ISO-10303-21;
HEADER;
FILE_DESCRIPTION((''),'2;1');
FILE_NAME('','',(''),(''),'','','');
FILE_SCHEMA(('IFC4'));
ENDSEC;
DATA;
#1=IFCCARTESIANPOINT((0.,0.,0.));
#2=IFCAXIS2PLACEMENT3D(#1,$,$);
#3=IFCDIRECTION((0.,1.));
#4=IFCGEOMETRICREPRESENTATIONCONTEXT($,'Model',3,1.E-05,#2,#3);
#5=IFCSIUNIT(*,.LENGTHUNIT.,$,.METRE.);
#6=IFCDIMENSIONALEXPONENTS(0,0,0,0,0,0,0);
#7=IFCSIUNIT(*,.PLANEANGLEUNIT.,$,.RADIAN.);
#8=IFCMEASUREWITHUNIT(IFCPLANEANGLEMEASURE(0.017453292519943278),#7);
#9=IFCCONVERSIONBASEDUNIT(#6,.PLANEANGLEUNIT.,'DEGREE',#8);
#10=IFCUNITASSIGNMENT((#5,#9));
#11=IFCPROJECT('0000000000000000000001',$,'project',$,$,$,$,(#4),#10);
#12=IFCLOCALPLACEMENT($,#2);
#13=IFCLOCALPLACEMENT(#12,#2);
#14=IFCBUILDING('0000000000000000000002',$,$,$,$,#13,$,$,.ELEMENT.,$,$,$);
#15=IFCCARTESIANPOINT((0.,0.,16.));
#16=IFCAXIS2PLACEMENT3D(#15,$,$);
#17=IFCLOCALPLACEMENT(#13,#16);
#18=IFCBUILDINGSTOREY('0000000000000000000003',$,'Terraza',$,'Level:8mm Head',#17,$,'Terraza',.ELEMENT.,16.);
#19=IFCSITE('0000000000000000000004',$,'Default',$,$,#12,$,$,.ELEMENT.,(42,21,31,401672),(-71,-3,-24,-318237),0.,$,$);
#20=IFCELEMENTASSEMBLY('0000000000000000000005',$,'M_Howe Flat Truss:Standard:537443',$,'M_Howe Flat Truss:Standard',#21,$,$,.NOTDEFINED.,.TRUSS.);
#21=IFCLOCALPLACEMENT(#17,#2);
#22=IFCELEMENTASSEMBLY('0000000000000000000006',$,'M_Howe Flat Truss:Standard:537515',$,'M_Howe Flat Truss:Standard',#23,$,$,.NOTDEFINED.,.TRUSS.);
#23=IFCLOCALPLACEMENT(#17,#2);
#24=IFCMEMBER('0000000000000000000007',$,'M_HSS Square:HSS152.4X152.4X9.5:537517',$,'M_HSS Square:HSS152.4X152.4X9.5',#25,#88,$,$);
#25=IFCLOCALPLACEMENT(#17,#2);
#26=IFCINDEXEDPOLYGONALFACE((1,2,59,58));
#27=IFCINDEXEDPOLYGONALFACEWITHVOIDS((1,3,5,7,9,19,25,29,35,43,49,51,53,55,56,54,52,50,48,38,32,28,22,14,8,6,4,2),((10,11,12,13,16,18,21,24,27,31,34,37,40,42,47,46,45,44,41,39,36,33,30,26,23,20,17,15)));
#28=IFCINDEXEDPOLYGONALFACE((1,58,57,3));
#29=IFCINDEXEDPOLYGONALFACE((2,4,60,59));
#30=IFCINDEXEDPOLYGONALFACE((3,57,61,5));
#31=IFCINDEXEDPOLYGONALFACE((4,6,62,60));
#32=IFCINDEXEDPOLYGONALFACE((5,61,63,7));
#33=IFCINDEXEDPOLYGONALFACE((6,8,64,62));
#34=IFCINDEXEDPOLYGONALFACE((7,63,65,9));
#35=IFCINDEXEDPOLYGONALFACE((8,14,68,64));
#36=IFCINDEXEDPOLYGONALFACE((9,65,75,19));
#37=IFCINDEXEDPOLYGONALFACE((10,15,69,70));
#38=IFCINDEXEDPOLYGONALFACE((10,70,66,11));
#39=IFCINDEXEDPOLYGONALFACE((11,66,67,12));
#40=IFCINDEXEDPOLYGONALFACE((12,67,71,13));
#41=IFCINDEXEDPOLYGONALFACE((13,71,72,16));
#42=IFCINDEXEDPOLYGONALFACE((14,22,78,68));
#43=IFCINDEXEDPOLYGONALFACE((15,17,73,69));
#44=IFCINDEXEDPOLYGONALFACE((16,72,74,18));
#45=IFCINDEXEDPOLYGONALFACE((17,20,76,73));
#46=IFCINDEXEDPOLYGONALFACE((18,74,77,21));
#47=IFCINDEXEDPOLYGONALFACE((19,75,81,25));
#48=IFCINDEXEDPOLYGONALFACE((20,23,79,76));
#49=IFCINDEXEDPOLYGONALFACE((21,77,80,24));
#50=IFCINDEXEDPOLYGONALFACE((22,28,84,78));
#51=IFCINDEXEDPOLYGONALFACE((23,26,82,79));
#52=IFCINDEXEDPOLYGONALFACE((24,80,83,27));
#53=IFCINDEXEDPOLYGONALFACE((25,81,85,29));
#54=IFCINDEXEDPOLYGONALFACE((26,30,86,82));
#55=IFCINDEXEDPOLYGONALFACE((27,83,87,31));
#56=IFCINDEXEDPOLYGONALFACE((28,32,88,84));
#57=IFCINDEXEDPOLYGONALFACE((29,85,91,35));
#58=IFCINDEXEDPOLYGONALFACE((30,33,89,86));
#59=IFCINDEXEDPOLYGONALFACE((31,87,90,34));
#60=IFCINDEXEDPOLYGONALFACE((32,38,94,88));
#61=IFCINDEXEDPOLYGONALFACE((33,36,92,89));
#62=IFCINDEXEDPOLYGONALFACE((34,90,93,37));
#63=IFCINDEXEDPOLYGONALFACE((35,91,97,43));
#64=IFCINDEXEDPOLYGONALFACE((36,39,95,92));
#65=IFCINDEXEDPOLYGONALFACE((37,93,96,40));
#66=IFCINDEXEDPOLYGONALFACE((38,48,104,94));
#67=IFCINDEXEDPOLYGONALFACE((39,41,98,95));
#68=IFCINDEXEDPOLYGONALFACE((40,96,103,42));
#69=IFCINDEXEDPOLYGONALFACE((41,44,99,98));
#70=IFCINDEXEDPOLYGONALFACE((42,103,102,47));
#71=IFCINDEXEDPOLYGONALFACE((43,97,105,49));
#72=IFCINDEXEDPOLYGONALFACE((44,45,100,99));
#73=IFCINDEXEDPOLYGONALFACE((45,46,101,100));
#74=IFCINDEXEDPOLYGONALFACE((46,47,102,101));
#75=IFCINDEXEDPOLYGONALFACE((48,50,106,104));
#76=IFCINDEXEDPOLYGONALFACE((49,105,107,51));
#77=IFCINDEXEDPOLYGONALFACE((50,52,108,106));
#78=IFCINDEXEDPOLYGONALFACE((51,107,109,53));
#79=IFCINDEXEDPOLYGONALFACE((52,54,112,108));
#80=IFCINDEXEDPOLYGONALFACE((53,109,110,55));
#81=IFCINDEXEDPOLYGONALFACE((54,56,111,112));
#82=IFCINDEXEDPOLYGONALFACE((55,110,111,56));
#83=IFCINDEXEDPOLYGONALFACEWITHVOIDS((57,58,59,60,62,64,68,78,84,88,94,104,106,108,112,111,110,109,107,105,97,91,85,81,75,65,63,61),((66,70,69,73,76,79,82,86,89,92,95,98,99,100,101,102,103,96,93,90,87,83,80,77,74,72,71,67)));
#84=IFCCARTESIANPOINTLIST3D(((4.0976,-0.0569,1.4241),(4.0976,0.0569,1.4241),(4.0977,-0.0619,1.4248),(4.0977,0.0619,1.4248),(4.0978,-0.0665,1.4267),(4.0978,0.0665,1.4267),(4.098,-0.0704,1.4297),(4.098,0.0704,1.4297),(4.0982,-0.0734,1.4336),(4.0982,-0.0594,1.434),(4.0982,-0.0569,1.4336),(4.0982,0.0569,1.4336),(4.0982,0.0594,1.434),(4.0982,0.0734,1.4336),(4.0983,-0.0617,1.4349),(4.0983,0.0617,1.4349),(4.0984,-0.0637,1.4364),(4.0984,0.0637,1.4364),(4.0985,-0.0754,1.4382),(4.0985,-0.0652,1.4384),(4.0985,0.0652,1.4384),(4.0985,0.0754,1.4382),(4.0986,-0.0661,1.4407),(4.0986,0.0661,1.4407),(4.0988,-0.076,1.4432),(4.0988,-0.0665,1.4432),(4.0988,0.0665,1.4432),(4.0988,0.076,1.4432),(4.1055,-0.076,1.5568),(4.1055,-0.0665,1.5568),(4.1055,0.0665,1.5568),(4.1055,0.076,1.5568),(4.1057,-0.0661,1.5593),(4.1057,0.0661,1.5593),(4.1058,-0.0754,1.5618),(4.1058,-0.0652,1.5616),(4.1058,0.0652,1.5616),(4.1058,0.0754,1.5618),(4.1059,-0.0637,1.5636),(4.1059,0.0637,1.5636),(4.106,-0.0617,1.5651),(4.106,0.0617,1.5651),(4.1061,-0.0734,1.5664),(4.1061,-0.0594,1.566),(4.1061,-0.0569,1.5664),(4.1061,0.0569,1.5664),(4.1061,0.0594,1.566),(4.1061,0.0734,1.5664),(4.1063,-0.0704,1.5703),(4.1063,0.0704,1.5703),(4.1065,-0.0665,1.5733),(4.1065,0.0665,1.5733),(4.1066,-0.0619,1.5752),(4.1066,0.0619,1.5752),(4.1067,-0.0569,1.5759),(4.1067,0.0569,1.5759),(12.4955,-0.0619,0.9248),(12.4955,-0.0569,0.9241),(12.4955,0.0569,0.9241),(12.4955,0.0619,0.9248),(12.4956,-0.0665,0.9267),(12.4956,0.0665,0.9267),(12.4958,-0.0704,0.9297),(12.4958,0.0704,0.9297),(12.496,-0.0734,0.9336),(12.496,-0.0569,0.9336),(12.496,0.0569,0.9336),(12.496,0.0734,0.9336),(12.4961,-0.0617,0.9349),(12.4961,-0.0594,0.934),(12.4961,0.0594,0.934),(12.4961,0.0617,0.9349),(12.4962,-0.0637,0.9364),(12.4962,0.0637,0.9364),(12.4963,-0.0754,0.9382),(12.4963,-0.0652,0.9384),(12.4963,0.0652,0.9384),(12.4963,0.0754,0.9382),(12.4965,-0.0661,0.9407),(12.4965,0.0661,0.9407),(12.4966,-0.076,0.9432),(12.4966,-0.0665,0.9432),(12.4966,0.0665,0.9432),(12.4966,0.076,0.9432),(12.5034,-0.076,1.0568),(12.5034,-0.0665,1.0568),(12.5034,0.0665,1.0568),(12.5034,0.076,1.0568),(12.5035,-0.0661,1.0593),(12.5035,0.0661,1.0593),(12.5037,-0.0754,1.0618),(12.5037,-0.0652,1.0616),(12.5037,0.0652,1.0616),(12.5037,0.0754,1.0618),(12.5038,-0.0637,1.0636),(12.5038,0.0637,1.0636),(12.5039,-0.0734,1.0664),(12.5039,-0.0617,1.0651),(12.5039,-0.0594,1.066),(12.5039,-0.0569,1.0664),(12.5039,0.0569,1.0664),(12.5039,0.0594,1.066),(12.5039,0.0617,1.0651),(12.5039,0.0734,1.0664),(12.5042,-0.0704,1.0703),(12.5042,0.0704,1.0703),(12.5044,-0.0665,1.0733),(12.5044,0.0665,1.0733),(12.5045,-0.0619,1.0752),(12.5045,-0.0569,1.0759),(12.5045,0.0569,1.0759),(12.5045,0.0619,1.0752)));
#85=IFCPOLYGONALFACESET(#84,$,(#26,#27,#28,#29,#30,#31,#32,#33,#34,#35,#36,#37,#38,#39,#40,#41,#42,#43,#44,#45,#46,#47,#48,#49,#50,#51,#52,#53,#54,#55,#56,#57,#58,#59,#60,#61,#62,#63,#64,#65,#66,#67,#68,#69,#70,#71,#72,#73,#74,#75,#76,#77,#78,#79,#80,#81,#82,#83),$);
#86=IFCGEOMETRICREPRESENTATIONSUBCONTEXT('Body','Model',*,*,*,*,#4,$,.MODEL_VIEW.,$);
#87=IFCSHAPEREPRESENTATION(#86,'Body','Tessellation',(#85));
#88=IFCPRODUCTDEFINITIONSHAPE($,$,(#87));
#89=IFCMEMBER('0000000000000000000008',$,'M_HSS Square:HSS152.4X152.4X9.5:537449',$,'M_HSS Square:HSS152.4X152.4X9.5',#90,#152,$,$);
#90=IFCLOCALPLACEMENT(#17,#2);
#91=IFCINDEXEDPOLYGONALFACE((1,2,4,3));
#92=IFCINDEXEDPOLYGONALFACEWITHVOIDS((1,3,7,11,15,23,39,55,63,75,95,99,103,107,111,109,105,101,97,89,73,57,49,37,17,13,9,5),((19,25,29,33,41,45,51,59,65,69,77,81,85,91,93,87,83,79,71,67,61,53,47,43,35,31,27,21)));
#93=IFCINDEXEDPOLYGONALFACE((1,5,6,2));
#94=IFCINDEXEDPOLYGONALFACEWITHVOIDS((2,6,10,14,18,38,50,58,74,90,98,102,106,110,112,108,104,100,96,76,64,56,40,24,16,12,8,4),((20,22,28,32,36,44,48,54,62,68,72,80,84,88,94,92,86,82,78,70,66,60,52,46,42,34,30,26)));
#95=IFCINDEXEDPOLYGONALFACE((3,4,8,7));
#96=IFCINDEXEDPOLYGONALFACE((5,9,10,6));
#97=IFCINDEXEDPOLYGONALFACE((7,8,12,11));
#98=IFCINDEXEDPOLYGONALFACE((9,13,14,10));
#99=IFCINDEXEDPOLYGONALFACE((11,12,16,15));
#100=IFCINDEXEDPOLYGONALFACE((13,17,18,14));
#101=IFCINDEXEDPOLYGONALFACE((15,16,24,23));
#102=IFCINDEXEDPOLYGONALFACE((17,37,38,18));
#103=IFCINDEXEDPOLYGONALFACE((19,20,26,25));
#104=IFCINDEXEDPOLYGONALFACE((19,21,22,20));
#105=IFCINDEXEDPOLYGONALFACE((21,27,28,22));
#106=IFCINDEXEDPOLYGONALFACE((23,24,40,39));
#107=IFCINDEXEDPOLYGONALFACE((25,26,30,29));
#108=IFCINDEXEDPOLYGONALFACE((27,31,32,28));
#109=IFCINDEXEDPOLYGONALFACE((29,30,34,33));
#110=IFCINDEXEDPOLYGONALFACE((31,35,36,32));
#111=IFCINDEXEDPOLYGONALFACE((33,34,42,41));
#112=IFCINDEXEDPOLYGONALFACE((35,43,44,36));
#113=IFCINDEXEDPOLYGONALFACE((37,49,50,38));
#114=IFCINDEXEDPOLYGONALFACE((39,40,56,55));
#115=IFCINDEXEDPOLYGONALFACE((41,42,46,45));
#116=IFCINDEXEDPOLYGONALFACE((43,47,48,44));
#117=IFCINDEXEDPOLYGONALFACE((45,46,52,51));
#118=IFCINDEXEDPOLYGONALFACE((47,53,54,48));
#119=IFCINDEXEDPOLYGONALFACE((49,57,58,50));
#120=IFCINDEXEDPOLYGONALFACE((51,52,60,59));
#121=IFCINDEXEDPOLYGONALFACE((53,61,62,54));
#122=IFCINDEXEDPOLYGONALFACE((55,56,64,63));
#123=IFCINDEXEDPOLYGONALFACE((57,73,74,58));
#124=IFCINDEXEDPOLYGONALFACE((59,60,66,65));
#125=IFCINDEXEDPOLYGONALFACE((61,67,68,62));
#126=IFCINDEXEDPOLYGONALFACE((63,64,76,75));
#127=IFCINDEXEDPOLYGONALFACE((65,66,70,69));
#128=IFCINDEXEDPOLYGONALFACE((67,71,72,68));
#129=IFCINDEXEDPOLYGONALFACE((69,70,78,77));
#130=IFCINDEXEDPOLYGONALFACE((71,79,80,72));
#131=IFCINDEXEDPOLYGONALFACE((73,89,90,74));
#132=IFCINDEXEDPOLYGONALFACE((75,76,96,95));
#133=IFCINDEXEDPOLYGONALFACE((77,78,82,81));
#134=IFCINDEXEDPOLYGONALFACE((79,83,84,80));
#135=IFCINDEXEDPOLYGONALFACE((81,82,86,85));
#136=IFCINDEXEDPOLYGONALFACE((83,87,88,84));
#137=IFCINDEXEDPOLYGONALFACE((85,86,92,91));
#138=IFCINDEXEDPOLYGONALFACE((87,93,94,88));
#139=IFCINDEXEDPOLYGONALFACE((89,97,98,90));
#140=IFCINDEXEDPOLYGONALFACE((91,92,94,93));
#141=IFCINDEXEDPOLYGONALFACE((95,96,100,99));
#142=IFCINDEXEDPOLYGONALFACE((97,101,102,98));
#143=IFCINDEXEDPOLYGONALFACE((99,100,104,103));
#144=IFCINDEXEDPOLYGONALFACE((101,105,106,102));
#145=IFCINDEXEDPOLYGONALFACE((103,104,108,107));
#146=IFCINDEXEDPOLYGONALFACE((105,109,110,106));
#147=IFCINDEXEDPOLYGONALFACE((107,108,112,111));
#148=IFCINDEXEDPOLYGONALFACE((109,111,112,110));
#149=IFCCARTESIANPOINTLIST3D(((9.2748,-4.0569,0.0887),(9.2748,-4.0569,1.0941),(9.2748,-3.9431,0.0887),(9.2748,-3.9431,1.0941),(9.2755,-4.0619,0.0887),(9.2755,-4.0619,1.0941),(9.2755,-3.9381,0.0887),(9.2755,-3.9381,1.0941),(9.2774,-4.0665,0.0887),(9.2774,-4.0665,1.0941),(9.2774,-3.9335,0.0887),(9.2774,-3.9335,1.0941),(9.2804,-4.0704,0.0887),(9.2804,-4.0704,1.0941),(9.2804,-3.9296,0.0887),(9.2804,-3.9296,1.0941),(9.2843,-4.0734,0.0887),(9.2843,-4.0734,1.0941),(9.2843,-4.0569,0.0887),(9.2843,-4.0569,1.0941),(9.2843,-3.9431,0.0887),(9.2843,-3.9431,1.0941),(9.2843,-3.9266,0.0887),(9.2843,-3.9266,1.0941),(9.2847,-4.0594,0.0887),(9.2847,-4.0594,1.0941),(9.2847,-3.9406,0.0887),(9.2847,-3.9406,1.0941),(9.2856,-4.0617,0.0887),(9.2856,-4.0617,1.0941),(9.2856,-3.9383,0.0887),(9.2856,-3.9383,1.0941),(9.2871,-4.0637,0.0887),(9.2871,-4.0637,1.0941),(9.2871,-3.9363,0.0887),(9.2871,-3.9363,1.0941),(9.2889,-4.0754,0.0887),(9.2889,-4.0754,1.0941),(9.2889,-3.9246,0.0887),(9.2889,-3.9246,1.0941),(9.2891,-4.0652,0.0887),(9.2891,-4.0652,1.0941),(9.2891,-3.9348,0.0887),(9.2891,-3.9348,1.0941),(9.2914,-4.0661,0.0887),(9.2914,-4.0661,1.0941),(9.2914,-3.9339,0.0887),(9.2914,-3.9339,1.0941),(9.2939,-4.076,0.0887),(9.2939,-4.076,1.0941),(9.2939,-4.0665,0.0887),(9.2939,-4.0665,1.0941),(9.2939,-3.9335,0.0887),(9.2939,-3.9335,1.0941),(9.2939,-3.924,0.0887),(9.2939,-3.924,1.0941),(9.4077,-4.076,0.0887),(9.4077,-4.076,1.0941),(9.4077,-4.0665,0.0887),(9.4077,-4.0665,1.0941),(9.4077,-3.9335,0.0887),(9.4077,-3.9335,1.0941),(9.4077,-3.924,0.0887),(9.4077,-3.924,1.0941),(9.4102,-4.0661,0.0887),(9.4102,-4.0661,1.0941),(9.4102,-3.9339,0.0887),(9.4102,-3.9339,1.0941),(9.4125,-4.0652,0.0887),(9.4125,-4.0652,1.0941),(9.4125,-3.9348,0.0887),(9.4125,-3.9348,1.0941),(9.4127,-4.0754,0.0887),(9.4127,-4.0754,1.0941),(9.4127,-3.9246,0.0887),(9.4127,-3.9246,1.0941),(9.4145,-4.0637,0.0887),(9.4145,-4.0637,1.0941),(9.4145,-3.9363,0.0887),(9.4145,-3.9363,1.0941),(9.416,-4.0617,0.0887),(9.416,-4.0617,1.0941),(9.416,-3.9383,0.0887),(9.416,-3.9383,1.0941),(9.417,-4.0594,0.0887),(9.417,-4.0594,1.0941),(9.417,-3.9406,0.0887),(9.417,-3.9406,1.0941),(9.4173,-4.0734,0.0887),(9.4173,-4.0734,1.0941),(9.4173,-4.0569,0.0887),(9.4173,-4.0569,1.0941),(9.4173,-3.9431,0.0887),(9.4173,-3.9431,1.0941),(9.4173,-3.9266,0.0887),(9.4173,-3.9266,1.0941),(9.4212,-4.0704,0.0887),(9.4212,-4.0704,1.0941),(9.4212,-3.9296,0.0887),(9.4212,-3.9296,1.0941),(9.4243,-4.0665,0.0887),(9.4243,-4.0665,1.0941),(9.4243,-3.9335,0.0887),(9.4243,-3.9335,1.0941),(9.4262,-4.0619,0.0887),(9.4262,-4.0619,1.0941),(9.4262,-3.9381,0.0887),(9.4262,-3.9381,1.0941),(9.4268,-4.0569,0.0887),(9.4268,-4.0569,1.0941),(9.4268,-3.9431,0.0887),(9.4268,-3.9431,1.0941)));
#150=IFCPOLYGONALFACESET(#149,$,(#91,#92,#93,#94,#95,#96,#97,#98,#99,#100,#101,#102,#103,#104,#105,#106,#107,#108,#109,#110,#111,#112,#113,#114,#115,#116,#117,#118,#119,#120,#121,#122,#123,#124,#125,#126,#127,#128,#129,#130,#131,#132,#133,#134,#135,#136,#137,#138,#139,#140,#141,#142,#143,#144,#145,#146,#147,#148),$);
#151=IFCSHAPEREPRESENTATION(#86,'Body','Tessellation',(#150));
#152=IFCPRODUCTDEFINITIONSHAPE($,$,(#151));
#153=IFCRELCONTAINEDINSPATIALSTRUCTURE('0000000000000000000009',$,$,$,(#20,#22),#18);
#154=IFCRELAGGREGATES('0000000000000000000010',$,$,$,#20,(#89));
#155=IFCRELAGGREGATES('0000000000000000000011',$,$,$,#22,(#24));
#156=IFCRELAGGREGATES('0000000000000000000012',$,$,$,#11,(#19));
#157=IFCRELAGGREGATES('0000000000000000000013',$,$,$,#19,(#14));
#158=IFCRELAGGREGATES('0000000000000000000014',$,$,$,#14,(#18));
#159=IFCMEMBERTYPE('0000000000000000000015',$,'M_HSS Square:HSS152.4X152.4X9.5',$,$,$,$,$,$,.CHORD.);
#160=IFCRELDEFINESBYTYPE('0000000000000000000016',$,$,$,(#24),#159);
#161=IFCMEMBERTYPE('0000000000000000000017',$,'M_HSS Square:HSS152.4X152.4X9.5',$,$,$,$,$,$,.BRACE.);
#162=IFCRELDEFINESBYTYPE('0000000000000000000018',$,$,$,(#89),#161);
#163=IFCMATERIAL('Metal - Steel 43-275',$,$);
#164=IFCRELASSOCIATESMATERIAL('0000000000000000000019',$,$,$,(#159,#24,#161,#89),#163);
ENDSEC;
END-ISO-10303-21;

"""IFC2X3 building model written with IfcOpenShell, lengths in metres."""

from ifc_helpers import new_model, entity, si_unit, converted_unit, direction, frame, frame_2d, origin, place, context, subcontext, project, spatial, polyline, circle_curve, parameter, trimmed, segment, composite_curve, outline, extrude, source, transform, mapped, material, type_object, type_shapes, element, aggregate, save


model = new_model("IFC2X3")

# Units and contexts
model_context = context("Model", 3, precision=1e-05, world=origin(), true_north=direction((0.0, 1.0)))
body_context = subcontext(model_context, "Body", "Model", "MODEL_VIEW")
ifc_project = project(units=[si_unit("LENGTHUNIT", "METRE"), converted_unit("PLANEANGLEUNIT", "DEGREE", entity("IfcPlaneAngleMeasure", 0.017453292519943278), si_unit("PLANEANGLEUNIT", "RADIAN"), dimensions=[0, 0, 0, 0, 0, 0, 0])], contexts=[model_context])

# Site, building, storey
site_placement = place(None, origin())
site = spatial("IfcSite", under=ifc_project, at=site_placement, Name="Default", CompositionType="ELEMENT", RefLatitude=(42, 21, 31, 401672), RefLongitude=(-71, -3, -24, -318237), RefElevation=0.0)
building_placement = place(site_placement, origin())
building = spatial("IfcBuilding", under=site, at=building_placement, CompositionType="ELEMENT")
storey_placement = place(building_placement, frame((0.0, 0.0, 16.0)))
storey = spatial("IfcBuildingStorey", under=building, at=storey_placement, Name="Terraza", ObjectType="Level:8mm Head", LongName="Terraza", CompositionType="ELEMENT", Elevation=16.0)

# Element assemblies, member
ifc_material_1 = material(Name="Metal - Steel 43-275")
member_type_1 = type_object("IfcMemberType", Name="M_HSS Square:HSS152.4X152.4X9.5", PredefinedType="CHORD", material=ifc_material_1)
shared_shape_1 = source(origin(), body_context, "Body", "SweptSolid", [
    extrude(outline(composite_curve([segment(polyline([(-0.0569, -0.076), (0.0569, -0.076)]), True, "CONTINUOUS"), segment(trimmed(circle_curve(frame_2d((0.0569, -0.0569), x_axis=(0.0, 1.0)), 0.0191), [parameter(180.0)], [parameter(270.0)], True, "PARAMETER"), True, "CONTINUOUS"), segment(polyline([(0.076, -0.0569), (0.076, 0.0569)]), True, "CONTINUOUS"), segment(trimmed(circle_curve(frame_2d((0.0569, 0.0569), x_axis=(0.0, 1.0)), 0.0191), [parameter(270.0)], [parameter(0.0)], True, "PARAMETER"), True, "CONTINUOUS"), segment(polyline([(0.0569, 0.076), (-0.0569, 0.076)]), True, "CONTINUOUS"), segment(trimmed(circle_curve(frame_2d((-0.0569, 0.0569), x_axis=(0.0, 1.0)), 0.0191), [parameter(0.0)], [parameter(90.0)], True, "PARAMETER"), True, "CONTINUOUS"), segment(polyline([(-0.076, 0.0569), (-0.076, -0.0569)]), True, "CONTINUOUS"), segment(trimmed(circle_curve(frame_2d((-0.0569, -0.0569), x_axis=(0.0, 1.0)), 0.0191), [parameter(90.0)], [parameter(180.0)], True, "PARAMETER"), True, "CONTINUOUS")], self_intersect=False), holes=[composite_curve([segment(trimmed(circle_curve(frame_2d((-0.0569, 0.0569), x_axis=(0.0, 1.0)), 0.0095), [parameter(360.0)], [parameter(90.0)], True, "PARAMETER"), False, "CONTINUOUS"), segment(polyline([(-0.0569, 0.0665), (0.0569, 0.0665)]), True, "CONTINUOUS"), segment(trimmed(circle_curve(frame_2d((0.0569, 0.0569), x_axis=(0.0, 1.0)), 0.0095), [parameter(270.0)], [parameter(360.0)], True, "PARAMETER"), False, "CONTINUOUS"), segment(polyline([(0.0665, 0.0569), (0.0665, -0.0569)]), True, "CONTINUOUS"), segment(trimmed(circle_curve(frame_2d((0.0569, -0.0569), x_axis=(0.0, 1.0)), 0.0095), [parameter(180.0)], [parameter(270.0)], True, "PARAMETER"), False, "CONTINUOUS"), segment(polyline([(0.0569, -0.0665), (-0.0569, -0.0665)]), True, "CONTINUOUS"), segment(trimmed(circle_curve(frame_2d((-0.0569, -0.0569), x_axis=(0.0, 1.0)), 0.0095), [parameter(90.0)], [parameter(180.0)], True, "PARAMETER"), False, "CONTINUOUS"), segment(polyline([(-0.0665, -0.0569), (-0.0665, 0.0569)]), True, "CONTINUOUS")], self_intersect=False)]), frame((-4.2064, 0.0, 0.0), z_axis=(1.0, 0.0, 0.0), x_axis=(0.0, 0.0, -1.0)), (0.0, 0.0, 1.0), 8.4127),
])
type_shapes(member_type_1, [shared_shape_1])
assembly_1_placement = place(storey_placement, origin())
assembly_1 = element("IfcElementAssembly", 1, at=assembly_1_placement, inside=storey, Name="M_Howe Flat Truss:Standard:537443", ObjectType="M_Howe Flat Truss:Standard", AssemblyPlace="NOTDEFINED", PredefinedType="TRUSS")
assembly_2_placement = place(storey_placement, origin())
assembly_2 = element("IfcElementAssembly", 2, at=assembly_2_placement, inside=storey, Name="M_Howe Flat Truss:Standard:537515", ObjectType="M_Howe Flat Truss:Standard", AssemblyPlace="NOTDEFINED", PredefinedType="TRUSS")
member_1_placement = place(assembly_2_placement, frame((8.3011, 0.0, 1.25), z_axis=(0.059434, 0.0, 0.998232), x_axis=(0.998232, 0.0, -0.059434)))
member_1 = element("IfcMember", 3, at=member_1_placement, type_object=member_type_1, material=ifc_material_1, Name="M_HSS Square:HSS152.4X152.4X9.5:537517", ObjectType="M_HSS Square:HSS152.4X152.4X9.5", context=body_context, shape_type="MappedRepresentation", body=[
    mapped(shared_shape_1, transform((0.0, 0.0, 0.0), scale=1.0)),
])

# Member
member_type_2 = type_object("IfcMemberType", Name="M_HSS Square:HSS152.4X152.4X9.5", PredefinedType="BRACE", material=ifc_material_1)
shared_shape_2 = source(origin(), body_context, "Body", "SweptSolid", [
    extrude(outline(composite_curve([segment(polyline([(-0.0569, -0.076), (0.0569, -0.076)]), True, "CONTINUOUS"), segment(trimmed(circle_curve(frame_2d((0.0569, -0.0569), x_axis=(0.0, 1.0)), 0.0191), [parameter(180.0)], [parameter(270.0)], True, "PARAMETER"), True, "CONTINUOUS"), segment(polyline([(0.076, -0.0569), (0.076, 0.0569)]), True, "CONTINUOUS"), segment(trimmed(circle_curve(frame_2d((0.0569, 0.0569), x_axis=(0.0, 1.0)), 0.0191), [parameter(270.0)], [parameter(0.0)], True, "PARAMETER"), True, "CONTINUOUS"), segment(polyline([(0.0569, 0.076), (-0.0569, 0.076)]), True, "CONTINUOUS"), segment(trimmed(circle_curve(frame_2d((-0.0569, 0.0569), x_axis=(0.0, 1.0)), 0.0191), [parameter(0.0)], [parameter(90.0)], True, "PARAMETER"), True, "CONTINUOUS"), segment(polyline([(-0.076, 0.0569), (-0.076, -0.0569)]), True, "CONTINUOUS"), segment(trimmed(circle_curve(frame_2d((-0.0569, -0.0569), x_axis=(0.0, 1.0)), 0.0191), [parameter(90.0)], [parameter(180.0)], True, "PARAMETER"), True, "CONTINUOUS")], self_intersect=False), holes=[composite_curve([segment(trimmed(circle_curve(frame_2d((-0.0569, 0.0569), x_axis=(0.0, 1.0)), 0.0095), [parameter(360.0)], [parameter(90.0)], True, "PARAMETER"), False, "CONTINUOUS"), segment(polyline([(-0.0569, 0.0665), (0.0569, 0.0665)]), True, "CONTINUOUS"), segment(trimmed(circle_curve(frame_2d((0.0569, 0.0569), x_axis=(0.0, 1.0)), 0.0095), [parameter(270.0)], [parameter(360.0)], True, "PARAMETER"), False, "CONTINUOUS"), segment(polyline([(0.0665, 0.0569), (0.0665, -0.0569)]), True, "CONTINUOUS"), segment(trimmed(circle_curve(frame_2d((0.0569, -0.0569), x_axis=(0.0, 1.0)), 0.0095), [parameter(180.0)], [parameter(270.0)], True, "PARAMETER"), False, "CONTINUOUS"), segment(polyline([(0.0569, -0.0665), (-0.0569, -0.0665)]), True, "CONTINUOUS"), segment(trimmed(circle_curve(frame_2d((-0.0569, -0.0569), x_axis=(0.0, 1.0)), 0.0095), [parameter(90.0)], [parameter(180.0)], True, "PARAMETER"), False, "CONTINUOUS"), segment(polyline([(-0.0665, -0.0569), (-0.0665, 0.0569)]), True, "CONTINUOUS")], self_intersect=False)]), frame((-0.505, 0.0, 0.0), z_axis=(1.0, 0.0, 0.0), x_axis=(0.0, 0.0, -1.0)), (0.0, 0.0, 1.0), 1.0054),
])
type_shapes(member_type_2, [shared_shape_2])
member_2_placement = place(assembly_1_placement, frame((9.3508, -4.0, 0.5937), z_axis=(1.0, 0.0, 0.0), x_axis=(0.0, 0.0, 1.0)))
member_2 = element("IfcMember", 4, at=member_2_placement, type_object=member_type_2, material=ifc_material_1, Name="M_HSS Square:HSS152.4X152.4X9.5:537449", ObjectType="M_HSS Square:HSS152.4X152.4X9.5", context=body_context, shape_type="MappedRepresentation", body=[
    mapped(shared_shape_2, transform((0.0, 0.0, 0.0), scale=1.0)),
])
aggregate(assembly_1, [member_2])
aggregate(assembly_2, [member_1])

save(model, "model.ifc")
